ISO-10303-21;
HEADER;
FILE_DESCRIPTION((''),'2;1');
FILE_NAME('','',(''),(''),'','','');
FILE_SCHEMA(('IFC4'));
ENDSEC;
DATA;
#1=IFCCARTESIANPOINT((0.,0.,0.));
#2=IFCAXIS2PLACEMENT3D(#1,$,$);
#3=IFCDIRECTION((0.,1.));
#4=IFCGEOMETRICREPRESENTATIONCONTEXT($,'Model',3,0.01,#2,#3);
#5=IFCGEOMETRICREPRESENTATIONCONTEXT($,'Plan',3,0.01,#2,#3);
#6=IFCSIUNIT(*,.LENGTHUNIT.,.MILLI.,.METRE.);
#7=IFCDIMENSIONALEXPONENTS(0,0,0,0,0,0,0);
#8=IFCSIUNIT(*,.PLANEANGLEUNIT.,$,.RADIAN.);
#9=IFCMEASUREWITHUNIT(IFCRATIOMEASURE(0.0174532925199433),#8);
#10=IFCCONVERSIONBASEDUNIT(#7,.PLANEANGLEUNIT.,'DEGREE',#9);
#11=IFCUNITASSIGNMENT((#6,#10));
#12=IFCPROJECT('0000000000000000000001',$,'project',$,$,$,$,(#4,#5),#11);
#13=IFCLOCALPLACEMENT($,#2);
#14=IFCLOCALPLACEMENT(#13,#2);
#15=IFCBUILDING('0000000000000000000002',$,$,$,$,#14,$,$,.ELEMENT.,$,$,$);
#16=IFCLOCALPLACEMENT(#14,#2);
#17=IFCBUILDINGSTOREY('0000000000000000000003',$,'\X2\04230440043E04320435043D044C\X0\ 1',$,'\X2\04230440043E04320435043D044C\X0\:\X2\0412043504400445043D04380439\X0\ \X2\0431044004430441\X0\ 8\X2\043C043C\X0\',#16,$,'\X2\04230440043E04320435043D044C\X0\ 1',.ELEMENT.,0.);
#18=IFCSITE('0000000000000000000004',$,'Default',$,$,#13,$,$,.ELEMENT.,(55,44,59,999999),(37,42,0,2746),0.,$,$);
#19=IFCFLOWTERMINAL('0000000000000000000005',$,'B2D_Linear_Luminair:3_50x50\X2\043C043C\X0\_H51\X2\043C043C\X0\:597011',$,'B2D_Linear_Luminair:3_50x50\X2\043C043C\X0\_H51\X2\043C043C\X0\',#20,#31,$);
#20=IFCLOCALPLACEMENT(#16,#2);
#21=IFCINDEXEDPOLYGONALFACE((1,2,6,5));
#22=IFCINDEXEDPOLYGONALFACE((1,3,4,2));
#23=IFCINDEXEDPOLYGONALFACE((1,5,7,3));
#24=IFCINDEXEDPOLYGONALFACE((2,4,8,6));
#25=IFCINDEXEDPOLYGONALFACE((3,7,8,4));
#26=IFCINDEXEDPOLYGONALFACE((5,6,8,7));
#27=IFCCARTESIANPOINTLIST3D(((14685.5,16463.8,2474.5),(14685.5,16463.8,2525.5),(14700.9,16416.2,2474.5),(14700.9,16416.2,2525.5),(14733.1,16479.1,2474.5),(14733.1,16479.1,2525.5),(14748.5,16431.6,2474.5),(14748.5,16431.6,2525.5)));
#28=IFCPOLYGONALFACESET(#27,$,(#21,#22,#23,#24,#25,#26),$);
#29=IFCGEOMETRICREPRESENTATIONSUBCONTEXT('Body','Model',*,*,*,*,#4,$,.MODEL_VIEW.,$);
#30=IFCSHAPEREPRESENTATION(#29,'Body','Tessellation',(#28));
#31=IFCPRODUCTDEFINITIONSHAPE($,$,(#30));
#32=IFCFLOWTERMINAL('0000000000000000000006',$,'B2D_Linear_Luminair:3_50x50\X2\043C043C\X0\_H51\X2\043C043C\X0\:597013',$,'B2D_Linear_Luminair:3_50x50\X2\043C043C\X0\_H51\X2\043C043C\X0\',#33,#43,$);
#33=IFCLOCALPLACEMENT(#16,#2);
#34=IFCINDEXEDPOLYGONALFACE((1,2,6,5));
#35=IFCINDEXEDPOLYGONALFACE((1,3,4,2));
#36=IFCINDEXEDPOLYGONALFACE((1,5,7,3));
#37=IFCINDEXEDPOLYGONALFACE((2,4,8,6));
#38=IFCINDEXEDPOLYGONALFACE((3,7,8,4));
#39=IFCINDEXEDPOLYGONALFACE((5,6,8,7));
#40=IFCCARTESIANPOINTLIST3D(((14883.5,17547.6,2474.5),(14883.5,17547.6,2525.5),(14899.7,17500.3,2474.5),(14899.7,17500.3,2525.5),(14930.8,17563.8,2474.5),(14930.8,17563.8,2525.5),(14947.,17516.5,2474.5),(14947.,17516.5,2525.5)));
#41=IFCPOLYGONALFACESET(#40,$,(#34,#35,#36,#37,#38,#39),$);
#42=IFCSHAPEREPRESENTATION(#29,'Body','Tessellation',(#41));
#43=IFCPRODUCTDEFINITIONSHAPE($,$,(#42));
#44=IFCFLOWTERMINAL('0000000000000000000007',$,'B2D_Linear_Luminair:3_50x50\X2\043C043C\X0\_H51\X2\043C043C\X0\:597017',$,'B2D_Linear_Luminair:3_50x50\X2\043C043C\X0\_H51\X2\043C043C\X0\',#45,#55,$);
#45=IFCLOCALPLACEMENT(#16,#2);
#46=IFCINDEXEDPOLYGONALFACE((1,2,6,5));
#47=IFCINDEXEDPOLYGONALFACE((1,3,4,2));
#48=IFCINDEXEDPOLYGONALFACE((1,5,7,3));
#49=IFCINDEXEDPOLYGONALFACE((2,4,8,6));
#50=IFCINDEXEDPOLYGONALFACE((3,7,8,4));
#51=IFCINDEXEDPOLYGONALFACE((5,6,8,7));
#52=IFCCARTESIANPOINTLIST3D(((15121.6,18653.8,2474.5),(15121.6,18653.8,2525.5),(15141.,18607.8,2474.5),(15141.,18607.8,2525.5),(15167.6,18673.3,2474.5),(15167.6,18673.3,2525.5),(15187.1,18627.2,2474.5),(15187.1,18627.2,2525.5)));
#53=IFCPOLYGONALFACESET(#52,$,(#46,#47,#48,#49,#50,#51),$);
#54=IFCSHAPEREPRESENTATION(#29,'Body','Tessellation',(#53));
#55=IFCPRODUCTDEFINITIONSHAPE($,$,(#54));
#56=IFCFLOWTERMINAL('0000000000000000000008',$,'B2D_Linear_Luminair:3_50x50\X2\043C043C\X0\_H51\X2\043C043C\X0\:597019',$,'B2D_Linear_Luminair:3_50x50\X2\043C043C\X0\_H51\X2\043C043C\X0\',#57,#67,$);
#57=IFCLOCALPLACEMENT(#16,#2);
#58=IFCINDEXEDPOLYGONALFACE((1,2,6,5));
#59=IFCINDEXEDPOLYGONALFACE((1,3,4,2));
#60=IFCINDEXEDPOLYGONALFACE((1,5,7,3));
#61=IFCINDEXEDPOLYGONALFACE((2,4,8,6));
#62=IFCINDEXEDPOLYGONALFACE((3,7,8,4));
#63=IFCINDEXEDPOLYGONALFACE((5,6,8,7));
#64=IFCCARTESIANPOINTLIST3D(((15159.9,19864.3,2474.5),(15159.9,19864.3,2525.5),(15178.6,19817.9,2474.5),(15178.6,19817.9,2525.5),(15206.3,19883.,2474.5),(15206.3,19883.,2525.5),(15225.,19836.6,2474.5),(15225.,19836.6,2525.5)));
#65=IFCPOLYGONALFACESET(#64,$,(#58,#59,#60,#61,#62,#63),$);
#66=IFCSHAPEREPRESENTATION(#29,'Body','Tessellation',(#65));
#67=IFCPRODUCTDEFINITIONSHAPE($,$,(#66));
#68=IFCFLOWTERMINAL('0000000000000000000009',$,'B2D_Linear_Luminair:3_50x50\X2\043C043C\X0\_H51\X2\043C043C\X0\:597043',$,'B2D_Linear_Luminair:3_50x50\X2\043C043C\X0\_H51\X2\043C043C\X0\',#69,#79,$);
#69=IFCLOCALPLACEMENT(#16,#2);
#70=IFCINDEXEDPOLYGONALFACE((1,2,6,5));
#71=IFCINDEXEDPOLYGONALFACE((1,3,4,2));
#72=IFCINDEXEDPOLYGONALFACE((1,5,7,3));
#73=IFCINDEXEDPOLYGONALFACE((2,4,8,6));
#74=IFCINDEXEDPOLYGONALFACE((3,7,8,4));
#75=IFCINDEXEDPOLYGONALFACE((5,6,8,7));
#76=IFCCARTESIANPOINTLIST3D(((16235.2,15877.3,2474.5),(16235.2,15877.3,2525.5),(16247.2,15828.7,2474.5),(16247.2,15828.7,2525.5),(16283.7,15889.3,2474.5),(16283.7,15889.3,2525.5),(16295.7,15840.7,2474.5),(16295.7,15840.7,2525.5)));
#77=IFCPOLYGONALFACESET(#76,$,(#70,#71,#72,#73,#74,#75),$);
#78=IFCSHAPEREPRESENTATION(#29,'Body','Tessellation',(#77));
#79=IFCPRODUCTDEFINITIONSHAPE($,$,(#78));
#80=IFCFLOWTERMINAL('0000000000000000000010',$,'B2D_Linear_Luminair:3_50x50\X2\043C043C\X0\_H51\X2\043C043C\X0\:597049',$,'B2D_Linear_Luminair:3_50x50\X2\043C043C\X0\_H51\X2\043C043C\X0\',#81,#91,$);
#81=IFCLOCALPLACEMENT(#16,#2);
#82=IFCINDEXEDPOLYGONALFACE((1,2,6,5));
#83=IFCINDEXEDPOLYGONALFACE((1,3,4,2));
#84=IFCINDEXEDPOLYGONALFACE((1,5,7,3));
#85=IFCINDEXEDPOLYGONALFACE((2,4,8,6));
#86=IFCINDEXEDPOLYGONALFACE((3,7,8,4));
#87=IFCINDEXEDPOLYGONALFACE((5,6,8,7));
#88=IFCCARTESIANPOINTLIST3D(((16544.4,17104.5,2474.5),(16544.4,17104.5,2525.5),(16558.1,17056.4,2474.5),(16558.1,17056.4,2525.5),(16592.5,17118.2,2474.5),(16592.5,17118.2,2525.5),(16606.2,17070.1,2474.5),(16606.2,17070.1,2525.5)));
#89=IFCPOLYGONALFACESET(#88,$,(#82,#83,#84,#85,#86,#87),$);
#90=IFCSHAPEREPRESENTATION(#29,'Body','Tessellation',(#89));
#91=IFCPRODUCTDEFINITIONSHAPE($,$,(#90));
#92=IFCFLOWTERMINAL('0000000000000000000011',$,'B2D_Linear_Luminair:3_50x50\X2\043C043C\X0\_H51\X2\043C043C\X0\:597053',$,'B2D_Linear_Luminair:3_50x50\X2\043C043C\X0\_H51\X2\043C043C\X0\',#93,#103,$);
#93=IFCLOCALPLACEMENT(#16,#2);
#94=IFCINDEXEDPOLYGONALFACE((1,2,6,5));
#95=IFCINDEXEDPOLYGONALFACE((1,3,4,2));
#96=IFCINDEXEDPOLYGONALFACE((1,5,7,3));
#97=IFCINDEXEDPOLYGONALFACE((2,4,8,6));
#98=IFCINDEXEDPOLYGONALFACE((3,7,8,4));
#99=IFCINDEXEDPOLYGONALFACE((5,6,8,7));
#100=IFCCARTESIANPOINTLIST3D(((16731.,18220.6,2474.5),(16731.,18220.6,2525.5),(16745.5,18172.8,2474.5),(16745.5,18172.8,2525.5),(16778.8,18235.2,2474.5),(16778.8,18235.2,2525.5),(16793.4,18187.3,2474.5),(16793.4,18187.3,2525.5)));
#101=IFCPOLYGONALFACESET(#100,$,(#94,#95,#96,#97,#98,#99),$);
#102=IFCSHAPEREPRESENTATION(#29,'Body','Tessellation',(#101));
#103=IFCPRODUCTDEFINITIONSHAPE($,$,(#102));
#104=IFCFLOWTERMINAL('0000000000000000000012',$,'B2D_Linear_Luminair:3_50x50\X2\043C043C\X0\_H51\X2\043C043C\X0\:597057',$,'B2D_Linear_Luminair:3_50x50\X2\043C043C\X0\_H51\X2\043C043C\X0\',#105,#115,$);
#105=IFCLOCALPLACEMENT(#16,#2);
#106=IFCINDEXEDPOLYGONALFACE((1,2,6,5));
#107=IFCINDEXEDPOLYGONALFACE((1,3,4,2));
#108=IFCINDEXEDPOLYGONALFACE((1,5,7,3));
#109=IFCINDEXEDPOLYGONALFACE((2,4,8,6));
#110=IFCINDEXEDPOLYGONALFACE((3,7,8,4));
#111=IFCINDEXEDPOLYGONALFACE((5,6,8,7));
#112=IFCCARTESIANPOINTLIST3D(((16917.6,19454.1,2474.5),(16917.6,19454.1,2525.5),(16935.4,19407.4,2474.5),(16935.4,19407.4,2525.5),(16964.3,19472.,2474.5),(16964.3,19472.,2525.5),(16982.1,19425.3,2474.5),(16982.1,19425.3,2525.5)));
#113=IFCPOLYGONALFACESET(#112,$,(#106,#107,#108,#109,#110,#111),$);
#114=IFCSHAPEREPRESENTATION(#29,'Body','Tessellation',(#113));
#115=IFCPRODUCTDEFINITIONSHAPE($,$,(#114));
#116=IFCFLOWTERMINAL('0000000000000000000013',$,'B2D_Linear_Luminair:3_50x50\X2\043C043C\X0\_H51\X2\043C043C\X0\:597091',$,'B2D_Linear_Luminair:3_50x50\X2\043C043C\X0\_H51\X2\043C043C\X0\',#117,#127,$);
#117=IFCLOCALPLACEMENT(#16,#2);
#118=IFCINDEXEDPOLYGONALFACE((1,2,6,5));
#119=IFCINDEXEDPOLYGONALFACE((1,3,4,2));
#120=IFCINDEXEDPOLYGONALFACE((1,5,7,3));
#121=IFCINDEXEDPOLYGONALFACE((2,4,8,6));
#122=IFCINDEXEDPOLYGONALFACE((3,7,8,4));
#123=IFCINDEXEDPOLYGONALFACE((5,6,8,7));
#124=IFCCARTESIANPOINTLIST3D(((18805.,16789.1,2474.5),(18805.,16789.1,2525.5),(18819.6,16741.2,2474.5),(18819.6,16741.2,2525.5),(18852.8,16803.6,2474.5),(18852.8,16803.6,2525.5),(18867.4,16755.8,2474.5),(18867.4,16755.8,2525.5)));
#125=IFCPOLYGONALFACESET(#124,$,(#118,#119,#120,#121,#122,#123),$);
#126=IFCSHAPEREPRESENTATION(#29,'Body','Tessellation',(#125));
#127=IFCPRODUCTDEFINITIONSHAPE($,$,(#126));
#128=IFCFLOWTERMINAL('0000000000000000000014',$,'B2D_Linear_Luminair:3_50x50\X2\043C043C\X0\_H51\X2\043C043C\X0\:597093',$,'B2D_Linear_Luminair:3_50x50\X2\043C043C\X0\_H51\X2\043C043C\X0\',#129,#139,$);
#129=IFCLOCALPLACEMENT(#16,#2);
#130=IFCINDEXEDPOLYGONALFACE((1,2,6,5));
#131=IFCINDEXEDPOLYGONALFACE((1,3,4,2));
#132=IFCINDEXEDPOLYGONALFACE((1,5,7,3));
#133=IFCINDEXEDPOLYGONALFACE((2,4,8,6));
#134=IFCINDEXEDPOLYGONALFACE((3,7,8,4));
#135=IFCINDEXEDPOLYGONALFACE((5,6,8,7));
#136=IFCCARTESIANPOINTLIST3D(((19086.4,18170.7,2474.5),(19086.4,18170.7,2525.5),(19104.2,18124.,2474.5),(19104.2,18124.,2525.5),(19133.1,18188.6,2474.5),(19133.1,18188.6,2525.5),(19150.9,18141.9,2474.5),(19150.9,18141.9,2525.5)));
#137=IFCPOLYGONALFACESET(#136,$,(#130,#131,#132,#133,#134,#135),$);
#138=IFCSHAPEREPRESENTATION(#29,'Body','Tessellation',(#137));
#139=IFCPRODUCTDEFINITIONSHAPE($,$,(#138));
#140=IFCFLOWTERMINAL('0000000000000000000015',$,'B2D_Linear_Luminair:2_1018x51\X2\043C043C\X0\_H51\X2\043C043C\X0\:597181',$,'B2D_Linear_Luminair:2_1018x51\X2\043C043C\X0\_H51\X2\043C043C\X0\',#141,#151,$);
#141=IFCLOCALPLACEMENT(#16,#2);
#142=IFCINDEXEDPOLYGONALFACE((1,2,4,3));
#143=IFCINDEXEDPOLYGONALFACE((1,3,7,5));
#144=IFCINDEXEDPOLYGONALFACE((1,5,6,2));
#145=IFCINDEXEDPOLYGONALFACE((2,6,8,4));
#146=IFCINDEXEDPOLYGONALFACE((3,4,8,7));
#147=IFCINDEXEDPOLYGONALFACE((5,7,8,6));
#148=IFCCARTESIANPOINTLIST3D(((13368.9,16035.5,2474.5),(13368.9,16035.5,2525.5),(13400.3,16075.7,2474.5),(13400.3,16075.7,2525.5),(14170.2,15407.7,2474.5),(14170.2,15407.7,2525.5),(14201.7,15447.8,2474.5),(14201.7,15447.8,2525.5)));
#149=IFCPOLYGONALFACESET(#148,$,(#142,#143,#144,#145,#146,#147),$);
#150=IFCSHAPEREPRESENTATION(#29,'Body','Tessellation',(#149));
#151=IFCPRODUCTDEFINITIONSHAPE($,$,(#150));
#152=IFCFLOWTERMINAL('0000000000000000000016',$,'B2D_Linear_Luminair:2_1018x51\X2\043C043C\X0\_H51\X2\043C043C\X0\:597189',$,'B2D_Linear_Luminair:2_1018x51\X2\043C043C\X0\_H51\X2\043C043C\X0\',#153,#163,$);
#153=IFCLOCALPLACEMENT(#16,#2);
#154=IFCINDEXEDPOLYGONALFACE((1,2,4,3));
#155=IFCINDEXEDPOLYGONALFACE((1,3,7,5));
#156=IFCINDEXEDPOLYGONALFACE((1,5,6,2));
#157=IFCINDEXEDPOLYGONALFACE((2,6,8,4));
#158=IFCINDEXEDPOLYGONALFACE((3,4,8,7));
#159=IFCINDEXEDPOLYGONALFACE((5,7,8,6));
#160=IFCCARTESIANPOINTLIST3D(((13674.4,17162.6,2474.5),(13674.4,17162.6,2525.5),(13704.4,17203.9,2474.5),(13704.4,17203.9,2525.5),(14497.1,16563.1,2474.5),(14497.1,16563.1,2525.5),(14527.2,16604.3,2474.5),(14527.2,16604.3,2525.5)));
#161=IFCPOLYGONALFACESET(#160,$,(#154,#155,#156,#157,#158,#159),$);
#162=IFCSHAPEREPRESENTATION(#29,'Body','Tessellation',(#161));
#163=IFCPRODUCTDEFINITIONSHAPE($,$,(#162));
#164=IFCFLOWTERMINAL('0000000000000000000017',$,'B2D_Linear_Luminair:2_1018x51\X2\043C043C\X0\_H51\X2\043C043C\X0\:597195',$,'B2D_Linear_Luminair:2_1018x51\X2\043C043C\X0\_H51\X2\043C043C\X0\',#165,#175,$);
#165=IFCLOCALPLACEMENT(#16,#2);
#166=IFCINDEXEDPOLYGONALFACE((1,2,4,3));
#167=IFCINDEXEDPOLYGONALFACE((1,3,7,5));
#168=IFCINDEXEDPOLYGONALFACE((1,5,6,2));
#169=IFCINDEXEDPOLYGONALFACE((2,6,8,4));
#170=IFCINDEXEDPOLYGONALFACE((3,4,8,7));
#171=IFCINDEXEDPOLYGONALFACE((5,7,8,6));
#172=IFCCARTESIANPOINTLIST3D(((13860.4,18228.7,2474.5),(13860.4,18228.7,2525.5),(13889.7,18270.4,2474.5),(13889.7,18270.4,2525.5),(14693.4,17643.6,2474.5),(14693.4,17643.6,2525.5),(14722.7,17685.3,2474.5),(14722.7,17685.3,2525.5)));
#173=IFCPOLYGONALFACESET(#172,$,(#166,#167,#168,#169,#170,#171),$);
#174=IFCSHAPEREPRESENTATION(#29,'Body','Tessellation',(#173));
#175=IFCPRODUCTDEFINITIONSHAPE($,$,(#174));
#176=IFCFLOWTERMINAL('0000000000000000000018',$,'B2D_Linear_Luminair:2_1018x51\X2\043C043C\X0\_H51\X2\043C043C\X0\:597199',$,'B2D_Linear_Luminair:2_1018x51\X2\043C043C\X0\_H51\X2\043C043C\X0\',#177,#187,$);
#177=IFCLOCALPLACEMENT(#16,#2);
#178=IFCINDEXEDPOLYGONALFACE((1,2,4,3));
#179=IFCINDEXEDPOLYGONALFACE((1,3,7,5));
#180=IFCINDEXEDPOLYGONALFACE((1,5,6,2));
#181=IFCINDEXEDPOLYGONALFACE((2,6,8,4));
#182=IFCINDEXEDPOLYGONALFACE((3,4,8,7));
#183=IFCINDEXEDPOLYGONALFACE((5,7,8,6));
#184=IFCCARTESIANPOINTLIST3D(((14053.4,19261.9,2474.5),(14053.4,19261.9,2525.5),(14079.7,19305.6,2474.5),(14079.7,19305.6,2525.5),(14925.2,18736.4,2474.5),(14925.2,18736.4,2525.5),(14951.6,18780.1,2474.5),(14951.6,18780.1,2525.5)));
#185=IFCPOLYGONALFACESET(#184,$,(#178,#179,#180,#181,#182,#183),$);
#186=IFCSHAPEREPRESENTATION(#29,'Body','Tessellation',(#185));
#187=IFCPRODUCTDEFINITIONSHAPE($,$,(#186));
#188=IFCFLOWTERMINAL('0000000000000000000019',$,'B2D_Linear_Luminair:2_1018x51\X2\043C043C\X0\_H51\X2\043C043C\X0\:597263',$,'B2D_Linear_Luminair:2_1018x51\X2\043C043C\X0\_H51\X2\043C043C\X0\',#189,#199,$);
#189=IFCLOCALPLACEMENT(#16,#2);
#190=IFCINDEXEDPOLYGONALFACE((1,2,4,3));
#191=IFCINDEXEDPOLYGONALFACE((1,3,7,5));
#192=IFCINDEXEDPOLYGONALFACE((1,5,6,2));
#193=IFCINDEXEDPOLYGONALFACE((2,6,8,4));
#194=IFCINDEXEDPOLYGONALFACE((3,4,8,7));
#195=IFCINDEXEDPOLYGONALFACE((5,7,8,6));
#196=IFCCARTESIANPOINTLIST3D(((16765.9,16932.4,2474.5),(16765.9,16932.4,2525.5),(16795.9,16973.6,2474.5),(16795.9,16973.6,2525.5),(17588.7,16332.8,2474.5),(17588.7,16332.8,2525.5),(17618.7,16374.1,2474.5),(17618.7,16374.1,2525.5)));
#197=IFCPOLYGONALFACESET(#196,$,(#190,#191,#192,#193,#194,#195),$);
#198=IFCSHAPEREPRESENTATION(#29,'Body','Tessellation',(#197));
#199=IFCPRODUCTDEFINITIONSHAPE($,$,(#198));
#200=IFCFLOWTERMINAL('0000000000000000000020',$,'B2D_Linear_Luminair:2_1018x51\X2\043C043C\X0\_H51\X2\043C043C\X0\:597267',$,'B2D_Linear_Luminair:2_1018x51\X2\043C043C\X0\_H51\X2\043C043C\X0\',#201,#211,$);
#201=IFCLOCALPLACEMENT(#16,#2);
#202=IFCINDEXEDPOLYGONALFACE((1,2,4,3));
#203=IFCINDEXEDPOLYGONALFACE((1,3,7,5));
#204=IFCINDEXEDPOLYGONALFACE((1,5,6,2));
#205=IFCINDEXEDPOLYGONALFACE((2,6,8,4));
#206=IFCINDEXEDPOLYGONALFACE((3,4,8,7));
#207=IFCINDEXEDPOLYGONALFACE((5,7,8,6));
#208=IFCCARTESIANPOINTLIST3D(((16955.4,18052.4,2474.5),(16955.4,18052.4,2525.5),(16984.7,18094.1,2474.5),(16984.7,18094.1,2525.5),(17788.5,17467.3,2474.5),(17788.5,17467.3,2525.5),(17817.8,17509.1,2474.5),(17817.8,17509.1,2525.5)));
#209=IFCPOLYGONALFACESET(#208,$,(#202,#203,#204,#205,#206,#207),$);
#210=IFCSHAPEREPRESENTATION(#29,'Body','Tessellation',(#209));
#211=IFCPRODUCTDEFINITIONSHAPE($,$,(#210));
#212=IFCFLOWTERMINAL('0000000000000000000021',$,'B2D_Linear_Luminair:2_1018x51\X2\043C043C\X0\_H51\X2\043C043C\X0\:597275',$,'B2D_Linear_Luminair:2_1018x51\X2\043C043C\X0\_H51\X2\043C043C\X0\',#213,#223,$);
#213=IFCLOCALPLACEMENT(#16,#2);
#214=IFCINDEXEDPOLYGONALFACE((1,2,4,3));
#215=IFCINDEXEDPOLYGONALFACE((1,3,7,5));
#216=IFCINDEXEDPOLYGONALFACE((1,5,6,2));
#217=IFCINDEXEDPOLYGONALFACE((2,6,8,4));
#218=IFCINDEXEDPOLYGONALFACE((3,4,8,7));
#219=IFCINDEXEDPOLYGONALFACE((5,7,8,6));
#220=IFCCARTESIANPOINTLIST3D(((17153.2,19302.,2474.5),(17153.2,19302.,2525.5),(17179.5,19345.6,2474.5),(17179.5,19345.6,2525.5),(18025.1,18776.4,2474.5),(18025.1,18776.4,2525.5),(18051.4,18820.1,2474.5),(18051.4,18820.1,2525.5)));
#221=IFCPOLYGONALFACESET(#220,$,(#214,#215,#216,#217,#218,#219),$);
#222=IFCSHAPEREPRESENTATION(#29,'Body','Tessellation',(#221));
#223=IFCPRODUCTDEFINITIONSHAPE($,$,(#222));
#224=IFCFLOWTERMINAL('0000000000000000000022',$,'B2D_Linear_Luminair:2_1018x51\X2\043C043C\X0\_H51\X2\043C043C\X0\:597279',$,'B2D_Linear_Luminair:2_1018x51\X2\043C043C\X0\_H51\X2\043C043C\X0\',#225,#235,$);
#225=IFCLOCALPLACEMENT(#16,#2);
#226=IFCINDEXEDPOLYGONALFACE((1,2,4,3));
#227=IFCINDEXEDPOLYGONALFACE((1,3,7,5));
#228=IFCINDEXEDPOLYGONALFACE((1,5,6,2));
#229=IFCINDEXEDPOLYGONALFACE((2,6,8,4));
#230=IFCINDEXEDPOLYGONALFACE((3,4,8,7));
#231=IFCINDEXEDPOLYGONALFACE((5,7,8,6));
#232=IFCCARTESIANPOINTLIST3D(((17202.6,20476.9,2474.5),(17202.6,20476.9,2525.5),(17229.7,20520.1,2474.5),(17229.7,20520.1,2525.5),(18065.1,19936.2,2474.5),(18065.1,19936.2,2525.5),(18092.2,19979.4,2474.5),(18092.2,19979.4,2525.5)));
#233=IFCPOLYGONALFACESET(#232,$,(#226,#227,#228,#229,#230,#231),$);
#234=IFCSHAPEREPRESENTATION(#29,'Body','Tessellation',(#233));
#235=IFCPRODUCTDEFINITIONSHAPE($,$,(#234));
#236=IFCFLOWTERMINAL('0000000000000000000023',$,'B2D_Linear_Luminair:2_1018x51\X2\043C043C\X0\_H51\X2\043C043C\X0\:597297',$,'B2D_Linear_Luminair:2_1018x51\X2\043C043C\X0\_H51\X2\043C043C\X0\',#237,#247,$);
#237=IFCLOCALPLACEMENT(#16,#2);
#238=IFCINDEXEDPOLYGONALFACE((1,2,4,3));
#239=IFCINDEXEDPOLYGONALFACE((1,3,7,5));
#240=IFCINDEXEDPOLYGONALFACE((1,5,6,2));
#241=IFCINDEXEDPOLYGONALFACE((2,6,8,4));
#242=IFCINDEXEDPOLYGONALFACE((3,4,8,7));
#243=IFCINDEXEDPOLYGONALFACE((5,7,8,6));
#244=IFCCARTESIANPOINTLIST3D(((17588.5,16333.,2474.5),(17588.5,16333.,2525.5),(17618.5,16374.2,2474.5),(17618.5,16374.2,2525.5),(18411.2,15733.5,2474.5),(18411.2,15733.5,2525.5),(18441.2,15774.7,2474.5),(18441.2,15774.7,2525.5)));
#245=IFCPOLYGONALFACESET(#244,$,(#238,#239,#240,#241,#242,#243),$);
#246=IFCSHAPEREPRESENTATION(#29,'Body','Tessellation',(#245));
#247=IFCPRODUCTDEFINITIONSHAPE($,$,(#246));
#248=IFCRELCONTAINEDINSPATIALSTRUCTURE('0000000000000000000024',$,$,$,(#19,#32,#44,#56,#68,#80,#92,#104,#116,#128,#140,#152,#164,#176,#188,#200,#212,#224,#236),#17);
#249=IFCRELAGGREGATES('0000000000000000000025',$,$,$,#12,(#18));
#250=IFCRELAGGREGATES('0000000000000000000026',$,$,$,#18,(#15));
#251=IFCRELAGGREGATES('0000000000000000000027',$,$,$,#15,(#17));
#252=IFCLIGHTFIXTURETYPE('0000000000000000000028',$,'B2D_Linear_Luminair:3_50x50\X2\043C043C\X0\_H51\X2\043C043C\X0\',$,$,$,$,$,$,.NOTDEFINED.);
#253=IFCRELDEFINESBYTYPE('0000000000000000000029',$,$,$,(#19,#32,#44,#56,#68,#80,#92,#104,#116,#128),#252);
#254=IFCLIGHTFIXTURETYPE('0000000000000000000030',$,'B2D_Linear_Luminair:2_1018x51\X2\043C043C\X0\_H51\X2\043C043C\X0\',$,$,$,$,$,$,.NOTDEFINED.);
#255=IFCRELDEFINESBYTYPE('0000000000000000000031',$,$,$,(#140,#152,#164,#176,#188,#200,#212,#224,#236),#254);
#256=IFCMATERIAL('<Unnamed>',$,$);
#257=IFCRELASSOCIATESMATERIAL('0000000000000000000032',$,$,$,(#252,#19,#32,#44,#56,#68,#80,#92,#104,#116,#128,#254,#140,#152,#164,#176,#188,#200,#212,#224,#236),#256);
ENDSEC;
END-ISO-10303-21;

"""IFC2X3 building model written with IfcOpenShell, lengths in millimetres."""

from ifc_helpers import new_model, entity, si_unit, converted_unit, direction, frame, origin, origin_2d_with_axis, place, context, subcontext, project, spatial, rectangle, extrude, source, transform, mapped, material, type_object, type_shapes, element, save


model = new_model("IFC2X3")

# Units and contexts
model_context = context("Model", 3, precision=0.01, world=origin(), true_north=direction((0.0, 1.0)))
plan_context = context("Plan", 3, precision=0.01, world=origin(), true_north=direction((0.0, 1.0)))
body_context = subcontext(model_context, "Body", "Model", "MODEL_VIEW")
ifc_project = project(units=[si_unit("LENGTHUNIT", "METRE", prefix="MILLI"), converted_unit("PLANEANGLEUNIT", "DEGREE", entity("IfcRatioMeasure", 0.0174532925199433), si_unit("PLANEANGLEUNIT", "RADIAN"), dimensions=[0, 0, 0, 0, 0, 0, 0])], contexts=[model_context, plan_context])

# Site, building, storey
site_placement = place(None, origin())
site = spatial("IfcSite", under=ifc_project, at=site_placement, Name="Default", CompositionType="ELEMENT", RefLatitude=(55, 44, 59, 999999), RefLongitude=(37, 42, 0, 2746), RefElevation=0.0)
building_placement = place(site_placement, origin())
building = spatial("IfcBuilding", under=site, at=building_placement, CompositionType="ELEMENT")
storey_placement = place(building_placement, origin())
storey = spatial("IfcBuildingStorey", under=building, at=storey_placement, Name="Уровень 1", ObjectType="Уровень:Верхний брус 8мм", LongName="Уровень 1", CompositionType="ELEMENT", Elevation=0.0)

# Flow terminals
ifc_material = material(Name="<Unnamed>")
light_fixture_type_1 = type_object("IfcLightFixtureType", Name="B2D_Linear_Luminair:3_50x50мм_H51мм", PredefinedType="NOTDEFINED", material=ifc_material)
shared_shape_1 = source(origin(), body_context, "Body", "SweptSolid", [
    extrude(rectangle(XDim=50.0, YDim=50.0, at=origin_2d_with_axis()), frame((0.0, 0.0, 0.0), z_axis=(0.0, 0.0, 1.0), x_axis=(-1.0, 0.0, 0.0)), (0.0, 0.0, 1.0), 51.0),
])
type_shapes(light_fixture_type_1, [shared_shape_1])
for number, where, z_axis, x_axis, name in (
    (1, (14717.0, 16447.7, 2525.5), (0.0, 0.0, -1.0), (0.951487, 0.307689, 0.0), "B2D_Linear_Luminair:3_50x50мм_H51мм:597011"),
    (2, (14915.3, 17532.0, 2525.5), (0.0, 0.0, -1.0), (0.945972, 0.324248, 0.0), "B2D_Linear_Luminair:3_50x50мм_H51мм:597013"),
    (3, (15154.3, 18640.5, 2525.5), (0.0, 0.0, -1.0), (0.92105, 0.389445, 0.0), "B2D_Linear_Luminair:3_50x50мм_H51мм:597017"),
    (4, (15192.5, 19850.4, 2525.5), (0.0, 0.0, -1.0), (0.927706, 0.373312, 0.0), "B2D_Linear_Luminair:3_50x50мм_H51мм:597019"),
    (5, (16265.4, 15859.0, 2525.5), (0.0, 0.0, -1.0), (0.970633, 0.240567, 0.0), "B2D_Linear_Luminair:3_50x50мм_H51мм:597043"),
    (6, (16575.3, 17087.3, 2525.5), (0.0, 0.0, -1.0), (0.961646, 0.274295, 0.0), "B2D_Linear_Luminair:3_50x50мм_H51мм:597049"),
    (7, (16762.2, 18204.0, 2525.5), (0.0, 0.0, -1.0), (0.956712, 0.291036, 0.0), "B2D_Linear_Luminair:3_50x50мм_H51мм:597053"),
    (8, (16949.8, 19439.7, 2525.5), (0.0, 0.0, -1.0), (0.93408, 0.357064, 0.0), "B2D_Linear_Luminair:3_50x50мм_H51мм:597057"),
    (9, (18836.2, 16772.4, 2525.5), (0.0, 0.0, -1.0), (0.956712, 0.291036, 0.0), "B2D_Linear_Luminair:3_50x50мм_H51мм:597091"),
    (10, (19118.7, 18156.3, 2525.5), (0.0, 0.0, -1.0), (0.93408, 0.357064, 0.0), "B2D_Linear_Luminair:3_50x50мм_H51мм:597093"),
):
    element("IfcFlowTerminal", number, at=place(storey_placement, frame(where, z_axis=z_axis, x_axis=x_axis)), inside=storey, type_object=light_fixture_type_1, material=ifc_material, Name=name, ObjectType="B2D_Linear_Luminair:3_50x50мм_H51мм", context=body_context, shape_type="MappedRepresentation", body=[
        mapped(shared_shape_1, transform((0.0, 0.0, 0.0), scale=1.0)),
    ])
light_fixture_type_2 = type_object("IfcLightFixtureType", Name="B2D_Linear_Luminair:2_1018x51мм_H51мм", PredefinedType="NOTDEFINED", material=ifc_material)
shared_shape_2 = source(origin(), body_context, "Body", "SweptSolid", [
    extrude(rectangle(XDim=1018.0, YDim=51.0, at=origin_2d_with_axis()), frame((0.0, 0.0, 0.0), z_axis=(0.0, 0.0, 1.0), x_axis=(-1.0, 0.0, 0.0)), (0.0, 0.0, 1.0), 51.0),
])
type_shapes(light_fixture_type_2, [shared_shape_2])
for number, where, z_axis, x_axis, name in (
    (11, (13785.3, 15741.7, 2525.5), (0.0, 0.0, -1.0), (0.78715, -0.616761, 0.0), "B2D_Linear_Luminair:2_1018x51мм_H51мм:597181"),
    (12, (14100.8, 16883.5, 2525.5), (0.0, 0.0, -1.0), (0.808196, -0.588914, 0.0), "B2D_Linear_Luminair:2_1018x51мм_H51мм:597189"),
    (13, (14291.5, 17957.0, 2525.5), (0.0, 0.0, -1.0), (0.81835, -0.57472, 0.0), "B2D_Linear_Luminair:2_1018x51мм_H51мм:597195"),
    (14, (14502.5, 19021.0, 2525.5), (0.0, 0.0, -1.0), (0.856447, -0.516234, 0.0), "B2D_Linear_Luminair:2_1018x51мм_H51мм:597199"),
    (15, (17192.3, 16653.2, 2525.5), (0.0, 0.0, -1.0), (0.808196, -0.588914, 0.0), "B2D_Linear_Luminair:2_1018x51мм_H51мм:597263"),
    (16, (17386.6, 17780.7, 2525.5), (0.0, 0.0, -1.0), (0.81835, -0.57472, 0.0), "B2D_Linear_Luminair:2_1018x51мм_H51мм:597267"),
    (17, (17602.3, 19061.0, 2525.5), (0.0, 0.0, -1.0), (0.856447, -0.516234, 0.0), "B2D_Linear_Luminair:2_1018x51мм_H51мм:597275"),
    (18, (17647.4, 20228.2, 2525.5), (0.0, 0.0, -1.0), (0.847307, -0.531103, 0.0), "B2D_Linear_Luminair:2_1018x51мм_H51мм:597279"),
    (19, (18014.9, 16053.9, 2525.5), (0.0, 0.0, -1.0), (0.808196, -0.588914, 0.0), "B2D_Linear_Luminair:2_1018x51мм_H51мм:597297"),
):
    element("IfcFlowTerminal", number, at=place(storey_placement, frame(where, z_axis=z_axis, x_axis=x_axis)), inside=storey, type_object=light_fixture_type_2, material=ifc_material, Name=name, ObjectType="B2D_Linear_Luminair:2_1018x51мм_H51мм", context=body_context, shape_type="MappedRepresentation", body=[
        mapped(shared_shape_2, transform((0.0, 0.0, 0.0), scale=1.0)),
    ])

save(model, "model.ifc")
